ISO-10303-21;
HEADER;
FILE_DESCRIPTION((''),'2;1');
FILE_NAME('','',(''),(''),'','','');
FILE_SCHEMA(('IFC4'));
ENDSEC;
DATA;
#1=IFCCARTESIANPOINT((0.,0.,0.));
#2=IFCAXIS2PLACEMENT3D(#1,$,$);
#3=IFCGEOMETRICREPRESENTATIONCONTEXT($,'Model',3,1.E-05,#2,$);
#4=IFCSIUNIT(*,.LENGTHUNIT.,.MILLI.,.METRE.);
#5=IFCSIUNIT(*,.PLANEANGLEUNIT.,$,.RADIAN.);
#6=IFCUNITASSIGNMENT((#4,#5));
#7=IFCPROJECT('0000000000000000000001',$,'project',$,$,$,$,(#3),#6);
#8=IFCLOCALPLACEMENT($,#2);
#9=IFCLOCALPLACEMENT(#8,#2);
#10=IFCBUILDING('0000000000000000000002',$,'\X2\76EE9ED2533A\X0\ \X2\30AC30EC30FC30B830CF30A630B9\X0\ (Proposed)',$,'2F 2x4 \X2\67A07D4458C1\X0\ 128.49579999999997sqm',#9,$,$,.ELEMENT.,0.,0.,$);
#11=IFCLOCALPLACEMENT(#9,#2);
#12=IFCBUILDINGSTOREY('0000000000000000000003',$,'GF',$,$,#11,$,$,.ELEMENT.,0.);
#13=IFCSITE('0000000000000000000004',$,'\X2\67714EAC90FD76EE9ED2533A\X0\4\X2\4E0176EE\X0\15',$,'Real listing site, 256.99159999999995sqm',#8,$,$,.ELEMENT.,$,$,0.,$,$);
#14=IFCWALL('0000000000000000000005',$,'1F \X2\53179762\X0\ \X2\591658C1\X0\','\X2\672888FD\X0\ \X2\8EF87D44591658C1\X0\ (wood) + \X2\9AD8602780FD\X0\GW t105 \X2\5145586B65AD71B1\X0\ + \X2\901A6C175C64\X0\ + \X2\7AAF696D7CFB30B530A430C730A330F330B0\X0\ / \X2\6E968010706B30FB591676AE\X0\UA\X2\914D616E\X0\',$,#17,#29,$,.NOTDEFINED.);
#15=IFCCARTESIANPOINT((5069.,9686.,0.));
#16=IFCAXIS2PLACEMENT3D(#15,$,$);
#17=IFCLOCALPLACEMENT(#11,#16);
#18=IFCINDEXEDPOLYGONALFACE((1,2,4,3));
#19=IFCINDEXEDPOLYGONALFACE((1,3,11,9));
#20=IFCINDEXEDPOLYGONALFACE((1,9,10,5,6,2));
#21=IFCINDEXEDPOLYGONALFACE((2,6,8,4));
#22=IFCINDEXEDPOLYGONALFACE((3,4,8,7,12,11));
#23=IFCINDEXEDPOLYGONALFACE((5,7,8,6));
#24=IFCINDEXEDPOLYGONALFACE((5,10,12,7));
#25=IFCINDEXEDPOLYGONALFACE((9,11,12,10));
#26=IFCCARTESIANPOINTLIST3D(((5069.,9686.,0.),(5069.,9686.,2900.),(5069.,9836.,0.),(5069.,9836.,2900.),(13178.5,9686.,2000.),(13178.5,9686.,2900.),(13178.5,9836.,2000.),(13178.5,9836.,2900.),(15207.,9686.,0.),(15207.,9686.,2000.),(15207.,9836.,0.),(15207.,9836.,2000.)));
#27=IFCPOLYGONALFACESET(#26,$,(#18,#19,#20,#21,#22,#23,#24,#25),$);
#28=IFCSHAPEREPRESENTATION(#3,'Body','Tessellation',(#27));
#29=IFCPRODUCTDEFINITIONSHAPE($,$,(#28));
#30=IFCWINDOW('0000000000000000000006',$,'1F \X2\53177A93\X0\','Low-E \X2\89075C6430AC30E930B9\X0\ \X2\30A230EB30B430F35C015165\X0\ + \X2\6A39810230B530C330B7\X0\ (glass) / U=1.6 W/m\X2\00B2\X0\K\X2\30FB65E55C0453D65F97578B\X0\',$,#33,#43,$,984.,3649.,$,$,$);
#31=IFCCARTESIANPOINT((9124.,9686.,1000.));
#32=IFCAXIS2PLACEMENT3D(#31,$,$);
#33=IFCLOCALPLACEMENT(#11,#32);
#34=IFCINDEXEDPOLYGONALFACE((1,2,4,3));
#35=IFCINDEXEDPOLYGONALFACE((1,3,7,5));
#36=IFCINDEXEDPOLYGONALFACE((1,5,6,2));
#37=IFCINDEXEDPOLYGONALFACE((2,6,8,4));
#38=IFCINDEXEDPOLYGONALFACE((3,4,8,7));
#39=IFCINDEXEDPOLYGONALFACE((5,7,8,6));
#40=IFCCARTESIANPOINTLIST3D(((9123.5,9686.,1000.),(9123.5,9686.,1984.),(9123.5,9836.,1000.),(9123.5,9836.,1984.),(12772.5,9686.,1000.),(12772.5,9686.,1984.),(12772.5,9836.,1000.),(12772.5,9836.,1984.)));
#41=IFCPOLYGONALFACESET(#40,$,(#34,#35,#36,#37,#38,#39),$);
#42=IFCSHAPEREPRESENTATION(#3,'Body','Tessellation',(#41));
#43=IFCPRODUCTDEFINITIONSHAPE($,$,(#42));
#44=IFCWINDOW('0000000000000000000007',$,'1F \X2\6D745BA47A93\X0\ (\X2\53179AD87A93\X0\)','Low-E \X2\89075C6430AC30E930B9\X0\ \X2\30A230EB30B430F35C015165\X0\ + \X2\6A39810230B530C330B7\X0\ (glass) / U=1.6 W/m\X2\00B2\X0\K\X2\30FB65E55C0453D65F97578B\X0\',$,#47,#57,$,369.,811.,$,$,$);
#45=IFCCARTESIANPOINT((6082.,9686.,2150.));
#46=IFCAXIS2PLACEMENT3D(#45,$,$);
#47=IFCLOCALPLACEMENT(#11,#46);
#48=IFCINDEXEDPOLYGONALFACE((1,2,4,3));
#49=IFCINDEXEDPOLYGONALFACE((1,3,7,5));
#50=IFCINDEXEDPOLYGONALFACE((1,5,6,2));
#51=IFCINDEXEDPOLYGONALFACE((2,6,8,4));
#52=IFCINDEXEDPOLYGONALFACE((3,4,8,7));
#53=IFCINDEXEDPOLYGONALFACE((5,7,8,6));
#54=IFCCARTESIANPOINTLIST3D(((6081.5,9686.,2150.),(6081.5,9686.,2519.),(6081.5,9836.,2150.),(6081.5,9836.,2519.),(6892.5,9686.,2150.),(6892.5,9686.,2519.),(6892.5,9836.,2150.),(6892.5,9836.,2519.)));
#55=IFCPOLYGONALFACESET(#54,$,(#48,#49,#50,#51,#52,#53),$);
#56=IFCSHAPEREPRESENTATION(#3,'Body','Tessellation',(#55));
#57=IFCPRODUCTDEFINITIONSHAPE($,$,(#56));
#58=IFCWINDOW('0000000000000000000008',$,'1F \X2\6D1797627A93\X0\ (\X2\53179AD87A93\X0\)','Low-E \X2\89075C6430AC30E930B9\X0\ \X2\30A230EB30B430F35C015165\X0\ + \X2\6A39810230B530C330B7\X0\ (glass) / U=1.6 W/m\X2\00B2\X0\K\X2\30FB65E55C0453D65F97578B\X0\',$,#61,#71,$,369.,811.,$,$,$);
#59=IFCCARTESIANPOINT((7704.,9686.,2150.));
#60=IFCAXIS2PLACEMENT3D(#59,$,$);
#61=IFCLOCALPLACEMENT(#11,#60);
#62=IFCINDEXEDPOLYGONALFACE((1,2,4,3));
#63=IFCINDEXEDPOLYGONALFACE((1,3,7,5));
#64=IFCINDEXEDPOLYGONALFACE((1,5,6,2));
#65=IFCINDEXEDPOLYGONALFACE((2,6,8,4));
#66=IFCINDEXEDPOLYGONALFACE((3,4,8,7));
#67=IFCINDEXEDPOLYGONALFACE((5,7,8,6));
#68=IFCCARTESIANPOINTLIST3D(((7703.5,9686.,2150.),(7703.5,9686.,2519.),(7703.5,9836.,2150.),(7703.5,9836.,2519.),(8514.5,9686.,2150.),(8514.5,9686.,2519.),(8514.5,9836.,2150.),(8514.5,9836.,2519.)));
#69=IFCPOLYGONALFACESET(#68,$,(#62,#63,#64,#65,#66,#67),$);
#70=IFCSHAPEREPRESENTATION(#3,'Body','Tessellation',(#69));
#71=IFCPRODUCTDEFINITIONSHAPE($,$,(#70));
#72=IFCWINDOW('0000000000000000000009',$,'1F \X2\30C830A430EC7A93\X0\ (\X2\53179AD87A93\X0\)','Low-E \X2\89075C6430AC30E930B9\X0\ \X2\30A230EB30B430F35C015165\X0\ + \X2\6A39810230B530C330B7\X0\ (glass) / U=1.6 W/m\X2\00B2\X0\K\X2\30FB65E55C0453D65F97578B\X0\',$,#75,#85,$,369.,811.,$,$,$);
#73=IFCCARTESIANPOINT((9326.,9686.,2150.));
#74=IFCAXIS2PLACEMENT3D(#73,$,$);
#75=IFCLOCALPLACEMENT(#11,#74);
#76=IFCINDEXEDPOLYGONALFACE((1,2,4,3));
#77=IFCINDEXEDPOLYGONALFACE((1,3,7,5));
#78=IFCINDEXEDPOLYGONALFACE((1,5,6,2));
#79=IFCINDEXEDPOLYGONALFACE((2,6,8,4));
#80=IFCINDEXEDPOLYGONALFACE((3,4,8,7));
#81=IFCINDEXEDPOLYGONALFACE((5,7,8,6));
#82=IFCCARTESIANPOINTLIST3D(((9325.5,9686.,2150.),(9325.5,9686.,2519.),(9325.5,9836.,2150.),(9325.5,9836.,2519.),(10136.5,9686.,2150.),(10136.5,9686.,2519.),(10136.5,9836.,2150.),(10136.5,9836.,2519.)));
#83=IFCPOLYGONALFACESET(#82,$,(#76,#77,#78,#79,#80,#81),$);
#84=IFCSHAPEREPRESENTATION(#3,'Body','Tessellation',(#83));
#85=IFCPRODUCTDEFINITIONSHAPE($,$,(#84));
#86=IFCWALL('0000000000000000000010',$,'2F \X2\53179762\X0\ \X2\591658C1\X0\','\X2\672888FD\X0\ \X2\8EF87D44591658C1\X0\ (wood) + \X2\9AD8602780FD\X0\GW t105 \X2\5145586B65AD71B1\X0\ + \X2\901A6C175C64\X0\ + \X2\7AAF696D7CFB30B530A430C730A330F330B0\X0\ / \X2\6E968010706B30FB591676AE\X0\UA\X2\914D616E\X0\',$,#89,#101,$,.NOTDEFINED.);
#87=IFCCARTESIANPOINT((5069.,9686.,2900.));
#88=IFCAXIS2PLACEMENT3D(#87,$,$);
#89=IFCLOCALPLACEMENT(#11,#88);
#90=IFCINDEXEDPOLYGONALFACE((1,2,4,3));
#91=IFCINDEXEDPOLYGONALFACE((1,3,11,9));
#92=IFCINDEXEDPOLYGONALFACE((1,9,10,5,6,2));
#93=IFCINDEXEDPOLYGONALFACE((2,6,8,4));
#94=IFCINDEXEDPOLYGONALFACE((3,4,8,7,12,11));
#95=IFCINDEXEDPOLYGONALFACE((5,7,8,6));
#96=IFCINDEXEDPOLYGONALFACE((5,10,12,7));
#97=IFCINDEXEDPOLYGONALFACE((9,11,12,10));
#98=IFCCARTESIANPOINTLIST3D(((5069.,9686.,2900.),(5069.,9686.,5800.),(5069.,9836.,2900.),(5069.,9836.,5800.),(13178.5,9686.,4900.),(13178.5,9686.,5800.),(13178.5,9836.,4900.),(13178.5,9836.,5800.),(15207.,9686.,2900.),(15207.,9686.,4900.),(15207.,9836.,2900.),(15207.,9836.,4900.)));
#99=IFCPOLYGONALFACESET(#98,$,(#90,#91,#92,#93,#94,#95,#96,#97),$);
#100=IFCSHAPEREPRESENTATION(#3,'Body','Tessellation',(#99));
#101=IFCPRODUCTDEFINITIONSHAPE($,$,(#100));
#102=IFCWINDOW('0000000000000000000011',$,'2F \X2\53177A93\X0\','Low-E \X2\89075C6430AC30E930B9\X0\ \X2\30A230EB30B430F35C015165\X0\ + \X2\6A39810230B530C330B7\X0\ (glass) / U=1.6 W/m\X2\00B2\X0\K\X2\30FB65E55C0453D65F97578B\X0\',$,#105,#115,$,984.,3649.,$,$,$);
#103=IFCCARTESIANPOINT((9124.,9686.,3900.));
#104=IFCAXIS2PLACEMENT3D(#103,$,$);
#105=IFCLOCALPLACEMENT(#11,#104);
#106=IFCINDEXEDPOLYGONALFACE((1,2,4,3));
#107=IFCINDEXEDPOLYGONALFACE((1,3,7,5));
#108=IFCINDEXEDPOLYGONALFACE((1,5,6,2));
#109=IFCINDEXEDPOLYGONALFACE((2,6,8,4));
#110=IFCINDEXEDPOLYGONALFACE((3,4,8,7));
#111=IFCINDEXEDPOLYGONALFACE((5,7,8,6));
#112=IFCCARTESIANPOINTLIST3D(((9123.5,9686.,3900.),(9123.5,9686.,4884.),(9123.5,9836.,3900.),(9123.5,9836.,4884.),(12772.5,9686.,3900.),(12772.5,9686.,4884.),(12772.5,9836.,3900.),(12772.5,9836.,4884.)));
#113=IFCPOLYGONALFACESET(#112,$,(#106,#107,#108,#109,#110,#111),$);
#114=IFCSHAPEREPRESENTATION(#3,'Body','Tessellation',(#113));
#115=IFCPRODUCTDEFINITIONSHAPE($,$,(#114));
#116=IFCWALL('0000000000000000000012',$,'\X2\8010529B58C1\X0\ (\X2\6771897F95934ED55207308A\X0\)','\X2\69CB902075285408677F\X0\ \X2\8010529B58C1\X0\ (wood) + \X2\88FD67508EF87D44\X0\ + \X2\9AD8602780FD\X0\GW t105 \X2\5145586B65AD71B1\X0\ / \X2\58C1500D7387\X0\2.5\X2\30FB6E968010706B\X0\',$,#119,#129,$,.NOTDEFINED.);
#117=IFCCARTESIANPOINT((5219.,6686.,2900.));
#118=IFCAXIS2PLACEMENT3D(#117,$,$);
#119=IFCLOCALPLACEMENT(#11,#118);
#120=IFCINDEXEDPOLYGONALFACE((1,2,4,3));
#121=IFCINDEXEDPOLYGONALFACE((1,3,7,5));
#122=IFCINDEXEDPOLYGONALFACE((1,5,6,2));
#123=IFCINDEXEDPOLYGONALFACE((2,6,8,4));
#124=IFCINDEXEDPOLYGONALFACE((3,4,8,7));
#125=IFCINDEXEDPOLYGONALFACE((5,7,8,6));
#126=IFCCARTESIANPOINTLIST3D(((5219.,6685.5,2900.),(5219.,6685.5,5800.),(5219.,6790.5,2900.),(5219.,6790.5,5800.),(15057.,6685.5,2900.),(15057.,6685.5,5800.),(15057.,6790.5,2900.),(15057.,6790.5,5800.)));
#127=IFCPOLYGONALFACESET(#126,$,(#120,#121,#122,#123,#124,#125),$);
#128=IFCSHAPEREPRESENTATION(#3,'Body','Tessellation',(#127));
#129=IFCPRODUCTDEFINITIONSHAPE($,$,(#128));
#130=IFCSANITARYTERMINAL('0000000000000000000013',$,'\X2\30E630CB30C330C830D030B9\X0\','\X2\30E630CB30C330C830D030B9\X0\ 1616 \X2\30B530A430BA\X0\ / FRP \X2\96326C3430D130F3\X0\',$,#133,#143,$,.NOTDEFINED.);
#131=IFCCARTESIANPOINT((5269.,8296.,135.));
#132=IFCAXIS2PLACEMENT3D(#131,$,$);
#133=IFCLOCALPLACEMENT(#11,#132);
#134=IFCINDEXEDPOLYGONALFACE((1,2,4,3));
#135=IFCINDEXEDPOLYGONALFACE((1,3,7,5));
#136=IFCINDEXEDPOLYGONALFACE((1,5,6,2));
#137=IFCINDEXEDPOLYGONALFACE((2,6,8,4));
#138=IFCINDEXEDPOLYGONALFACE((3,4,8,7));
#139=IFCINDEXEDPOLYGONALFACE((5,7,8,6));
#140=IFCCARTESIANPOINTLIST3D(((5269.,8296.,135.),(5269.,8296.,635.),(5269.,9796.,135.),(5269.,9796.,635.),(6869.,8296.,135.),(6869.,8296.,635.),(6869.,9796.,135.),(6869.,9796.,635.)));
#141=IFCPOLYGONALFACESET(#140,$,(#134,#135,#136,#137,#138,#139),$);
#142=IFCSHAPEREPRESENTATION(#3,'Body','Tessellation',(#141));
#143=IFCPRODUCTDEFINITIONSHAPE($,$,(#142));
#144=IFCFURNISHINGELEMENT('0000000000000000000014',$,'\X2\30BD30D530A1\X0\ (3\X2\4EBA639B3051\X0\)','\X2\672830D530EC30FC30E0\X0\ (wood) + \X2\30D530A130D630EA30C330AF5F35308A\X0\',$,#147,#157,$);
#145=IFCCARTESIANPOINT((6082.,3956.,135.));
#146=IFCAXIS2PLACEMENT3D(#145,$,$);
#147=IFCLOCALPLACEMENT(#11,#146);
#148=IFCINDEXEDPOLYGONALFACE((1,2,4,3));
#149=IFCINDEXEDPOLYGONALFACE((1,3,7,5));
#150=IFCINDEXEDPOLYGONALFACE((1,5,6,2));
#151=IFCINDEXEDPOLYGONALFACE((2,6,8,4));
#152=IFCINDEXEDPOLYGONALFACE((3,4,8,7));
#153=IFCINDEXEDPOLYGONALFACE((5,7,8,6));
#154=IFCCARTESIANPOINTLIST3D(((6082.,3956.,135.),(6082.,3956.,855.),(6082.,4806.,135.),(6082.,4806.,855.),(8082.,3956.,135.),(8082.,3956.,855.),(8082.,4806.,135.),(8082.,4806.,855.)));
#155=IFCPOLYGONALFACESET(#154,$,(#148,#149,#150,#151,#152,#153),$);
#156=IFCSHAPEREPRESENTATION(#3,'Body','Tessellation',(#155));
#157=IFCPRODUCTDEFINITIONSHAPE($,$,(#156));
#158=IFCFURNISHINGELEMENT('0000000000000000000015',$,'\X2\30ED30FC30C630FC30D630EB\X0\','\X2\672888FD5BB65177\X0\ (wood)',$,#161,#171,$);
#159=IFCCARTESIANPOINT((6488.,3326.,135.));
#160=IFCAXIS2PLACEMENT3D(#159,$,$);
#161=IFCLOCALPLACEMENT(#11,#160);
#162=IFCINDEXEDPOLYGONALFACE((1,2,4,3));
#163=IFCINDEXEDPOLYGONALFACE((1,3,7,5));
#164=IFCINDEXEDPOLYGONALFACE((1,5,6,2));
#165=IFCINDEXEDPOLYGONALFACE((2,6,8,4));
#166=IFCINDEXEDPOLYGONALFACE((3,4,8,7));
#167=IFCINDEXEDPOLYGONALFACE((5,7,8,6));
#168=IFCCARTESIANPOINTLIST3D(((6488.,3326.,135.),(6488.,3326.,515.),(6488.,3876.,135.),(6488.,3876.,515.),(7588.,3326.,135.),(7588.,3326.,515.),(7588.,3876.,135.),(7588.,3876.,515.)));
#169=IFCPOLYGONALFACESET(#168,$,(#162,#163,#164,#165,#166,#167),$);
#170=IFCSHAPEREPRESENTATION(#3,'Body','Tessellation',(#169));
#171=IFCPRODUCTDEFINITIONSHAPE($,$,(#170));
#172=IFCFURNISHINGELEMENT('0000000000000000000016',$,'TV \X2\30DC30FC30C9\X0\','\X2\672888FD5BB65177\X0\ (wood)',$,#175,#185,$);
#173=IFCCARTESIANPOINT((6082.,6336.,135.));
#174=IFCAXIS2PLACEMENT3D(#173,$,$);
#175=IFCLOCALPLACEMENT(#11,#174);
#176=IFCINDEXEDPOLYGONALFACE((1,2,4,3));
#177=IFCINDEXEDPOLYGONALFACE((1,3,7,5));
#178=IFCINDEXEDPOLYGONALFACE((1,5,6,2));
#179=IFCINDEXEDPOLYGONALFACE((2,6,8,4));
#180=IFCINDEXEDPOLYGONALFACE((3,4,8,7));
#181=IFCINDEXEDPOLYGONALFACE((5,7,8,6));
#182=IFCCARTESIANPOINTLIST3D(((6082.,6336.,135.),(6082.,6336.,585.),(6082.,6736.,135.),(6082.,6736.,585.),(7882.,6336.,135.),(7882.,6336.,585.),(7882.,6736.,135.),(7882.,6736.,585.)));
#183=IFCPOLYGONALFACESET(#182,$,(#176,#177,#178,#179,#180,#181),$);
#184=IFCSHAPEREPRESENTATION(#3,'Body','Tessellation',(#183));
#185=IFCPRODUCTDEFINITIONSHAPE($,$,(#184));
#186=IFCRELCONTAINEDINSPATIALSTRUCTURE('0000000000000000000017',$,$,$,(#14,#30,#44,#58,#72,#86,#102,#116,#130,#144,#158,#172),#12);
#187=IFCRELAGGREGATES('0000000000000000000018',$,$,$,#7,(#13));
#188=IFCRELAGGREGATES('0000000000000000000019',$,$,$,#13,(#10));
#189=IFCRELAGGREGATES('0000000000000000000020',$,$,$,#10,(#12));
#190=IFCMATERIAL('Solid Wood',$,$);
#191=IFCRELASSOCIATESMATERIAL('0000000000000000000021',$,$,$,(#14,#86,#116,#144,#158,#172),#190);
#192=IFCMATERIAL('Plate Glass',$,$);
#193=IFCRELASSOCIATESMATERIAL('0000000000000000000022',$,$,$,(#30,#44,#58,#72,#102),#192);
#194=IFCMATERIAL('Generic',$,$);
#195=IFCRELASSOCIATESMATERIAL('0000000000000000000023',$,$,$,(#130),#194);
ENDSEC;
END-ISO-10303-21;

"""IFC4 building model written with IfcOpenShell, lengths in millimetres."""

from ifc_helpers import new_model, si_unit, frame, frame_2d, origin, place, context, project, spatial, rectangle, extrude, material, element, fill, save


model = new_model("IFC4")

# Units and contexts
model_context = context("Model", 3, precision=1e-05, world=origin())
ifc_project = project(units=[si_unit("LENGTHUNIT", "METRE", prefix="MILLI"), si_unit("PLANEANGLEUNIT", "RADIAN")], contexts=[model_context])

# Site, building, storey
site_placement = place(None, origin())
site = spatial("IfcSite", under=ifc_project, at=site_placement, Name="東京都目黒区4丁目15", ObjectType="Real listing site, 256.99159999999995sqm", CompositionType="ELEMENT", RefElevation=0.0)
building_placement = place(site_placement, origin())
building = spatial("IfcBuilding", under=site, at=building_placement, Name="目黒区 ガレージハウス (Proposed)", ObjectType="2F 2x4 枠組壁 128.49579999999997sqm", CompositionType="ELEMENT", ElevationOfRefHeight=0.0, ElevationOfTerrain=0.0)
storey_placement = place(building_placement, origin())
storey = spatial("IfcBuildingStorey", under=building, at=storey_placement, Name="GF", CompositionType="ELEMENT", Elevation=0.0)

# Wall, openings, windows
ifc_material_1 = material(Name="Solid Wood")
wall_1_placement = place(storey_placement, frame((5069.0, 9686.0, 0.0)))
wall_1 = element("IfcWall", 1, at=wall_1_placement, inside=storey, material=ifc_material_1, Name="1F 北面 外壁", Description="木製 軸組外壁 (wood) + 高性能GW t105 充填断熱 + 通気層 + 窯業系サイディング / 準耐火・外皮UA配慮", PredefinedType="NOTDEFINED", context=model_context, shape_type="SweptSolid", body=[
    extrude(rectangle(XDim=10138.0, YDim=150.0, at=frame_2d((5069.0, 75.0))), frame((5069.0, 9686.0, 0.0)), (0.0, 0.0, 1.0), 2900.0),
])
opening_1_placement = place(storey_placement, frame((9124.0, 9686.0, 1000.0)))
opening_1 = element("IfcOpeningElement", 2, at=opening_1_placement, cuts=wall_1, PredefinedType="NOTDEFINED", context=model_context, shape_type="SweptSolid", body=[
    extrude(rectangle(XDim=3649.0, YDim=150.0, at=frame_2d((1824.0, 75.0))), frame((9124.0, 9686.0, 1000.0)), (0.0, 0.0, 1.0), 984.0),
])
opening_2_placement = place(storey_placement, frame((6082.0, 9686.0, 2150.0)))
opening_2 = element("IfcOpeningElement", 3, at=opening_2_placement, cuts=wall_1, PredefinedType="NOTDEFINED", context=model_context, shape_type="SweptSolid", body=[
    extrude(rectangle(XDim=811.0, YDim=150.0, at=frame_2d((405.0, 75.0))), frame((6082.0, 9686.0, 2150.0)), (0.0, 0.0, 1.0), 369.0),
])
opening_3_placement = place(storey_placement, frame((7704.0, 9686.0, 2150.0)))
opening_3 = element("IfcOpeningElement", 4, at=opening_3_placement, cuts=wall_1, PredefinedType="NOTDEFINED", context=model_context, shape_type="SweptSolid", body=[
    extrude(rectangle(XDim=811.0, YDim=150.0, at=frame_2d((405.0, 75.0))), frame((7704.0, 9686.0, 2150.0)), (0.0, 0.0, 1.0), 369.0),
])
opening_4_placement = place(storey_placement, frame((9326.0, 9686.0, 2150.0)))
opening_4 = element("IfcOpeningElement", 5, at=opening_4_placement, cuts=wall_1, PredefinedType="NOTDEFINED", context=model_context, shape_type="SweptSolid", body=[
    extrude(rectangle(XDim=811.0, YDim=150.0, at=frame_2d((405.0, 75.0))), frame((9326.0, 9686.0, 2150.0)), (0.0, 0.0, 1.0), 369.0),
])
ifc_material_2 = material(Name="Plate Glass")
window_1_placement = place(storey_placement, frame((9124.0, 9686.0, 1000.0)))
window_1 = element("IfcWindow", 6, at=window_1_placement, inside=storey, material=ifc_material_2, Name="1F 北窓", Description="Low-E 複層ガラス アルゴン封入 + 樹脂サッシ (glass) / U=1.6 W/m²K・日射取得型", OverallHeight=984.0, OverallWidth=3649.0, context=model_context, shape_type="SweptSolid", body=[
    extrude(rectangle(XDim=3649.0, YDim=150.0, at=frame_2d((1824.0, 75.0))), frame((9124.0, 9686.0, 1000.0)), (0.0, 0.0, 1.0), 984.0),
])
fill(opening_1, window_1)
window_2_placement = place(storey_placement, frame((6082.0, 9686.0, 2150.0)))
window_2 = element("IfcWindow", 7, at=window_2_placement, inside=storey, material=ifc_material_2, Name="1F 浴室窓 (北高窓)", Description="Low-E 複層ガラス アルゴン封入 + 樹脂サッシ (glass) / U=1.6 W/m²K・日射取得型", OverallHeight=369.0, OverallWidth=811.0, context=model_context, shape_type="SweptSolid", body=[
    extrude(rectangle(XDim=811.0, YDim=150.0, at=frame_2d((405.0, 75.0))), frame((6082.0, 9686.0, 2150.0)), (0.0, 0.0, 1.0), 369.0),
])
fill(opening_2, window_2)
window_3_placement = place(storey_placement, frame((7704.0, 9686.0, 2150.0)))
window_3 = element("IfcWindow", 8, at=window_3_placement, inside=storey, material=ifc_material_2, Name="1F 洗面窓 (北高窓)", Description="Low-E 複層ガラス アルゴン封入 + 樹脂サッシ (glass) / U=1.6 W/m²K・日射取得型", OverallHeight=369.0, OverallWidth=811.0, context=model_context, shape_type="SweptSolid", body=[
    extrude(rectangle(XDim=811.0, YDim=150.0, at=frame_2d((405.0, 75.0))), frame((7704.0, 9686.0, 2150.0)), (0.0, 0.0, 1.0), 369.0),
])
fill(opening_3, window_3)
window_4_placement = place(storey_placement, frame((9326.0, 9686.0, 2150.0)))
window_4 = element("IfcWindow", 9, at=window_4_placement, inside=storey, material=ifc_material_2, Name="1F トイレ窓 (北高窓)", Description="Low-E 複層ガラス アルゴン封入 + 樹脂サッシ (glass) / U=1.6 W/m²K・日射取得型", OverallHeight=369.0, OverallWidth=811.0, context=model_context, shape_type="SweptSolid", body=[
    extrude(rectangle(XDim=811.0, YDim=150.0, at=frame_2d((405.0, 75.0))), frame((9326.0, 9686.0, 2150.0)), (0.0, 0.0, 1.0), 369.0),
])
fill(opening_4, window_4)

# Wall, opening, window
wall_2_placement = place(storey_placement, frame((5069.0, 9686.0, 2900.0)))
wall_2 = element("IfcWall", 10, at=wall_2_placement, inside=storey, material=ifc_material_1, Name="2F 北面 外壁", Description="木製 軸組外壁 (wood) + 高性能GW t105 充填断熱 + 通気層 + 窯業系サイディング / 準耐火・外皮UA配慮", PredefinedType="NOTDEFINED", context=model_context, shape_type="SweptSolid", body=[
    extrude(rectangle(XDim=10138.0, YDim=150.0, at=frame_2d((5069.0, 75.0))), frame((5069.0, 9686.0, 2900.0)), (0.0, 0.0, 1.0), 2900.0),
])
opening_5_placement = place(storey_placement, frame((9124.0, 9686.0, 3900.0)))
opening_5 = element("IfcOpeningElement", 11, at=opening_5_placement, cuts=wall_2, PredefinedType="NOTDEFINED", context=model_context, shape_type="SweptSolid", body=[
    extrude(rectangle(XDim=3649.0, YDim=150.0, at=frame_2d((1824.0, 75.0))), frame((9124.0, 9686.0, 3900.0)), (0.0, 0.0, 1.0), 984.0),
])
window_5_placement = place(storey_placement, frame((9124.0, 9686.0, 3900.0)))
window_5 = element("IfcWindow", 12, at=window_5_placement, inside=storey, material=ifc_material_2, Name="2F 北窓", Description="Low-E 複層ガラス アルゴン封入 + 樹脂サッシ (glass) / U=1.6 W/m²K・日射取得型", OverallHeight=984.0, OverallWidth=3649.0, context=model_context, shape_type="SweptSolid", body=[
    extrude(rectangle(XDim=3649.0, YDim=150.0, at=frame_2d((1824.0, 75.0))), frame((9124.0, 9686.0, 3900.0)), (0.0, 0.0, 1.0), 984.0),
])
fill(opening_5, window_5)

# Wall
wall_3_placement = place(storey_placement, frame((5219.0, 6686.0, 2900.0)))
element("IfcWall", 13, at=wall_3_placement, inside=storey, material=ifc_material_1, Name="耐力壁 (東西間仕切り)", Description="構造用合板 耐力壁 (wood) + 製材軸組 + 高性能GW t105 充填断熱 / 壁倍率2.5・準耐火", PredefinedType="NOTDEFINED", context=model_context, shape_type="SweptSolid", body=[
    extrude(rectangle(XDim=9838.0, YDim=105.0, at=frame_2d((4919.0, 52.0))), frame((5219.0, 6686.0, 2900.0)), (0.0, 0.0, 1.0), 2900.0),
])

# Sanitary terminal
ifc_material_3 = material(Name="Generic")
sanitary_terminal_placement = place(storey_placement, frame((5269.0, 8296.0, 135.0)))
element("IfcSanitaryTerminal", 14, at=sanitary_terminal_placement, inside=storey, material=ifc_material_3, Name="ユニットバス", Description="ユニットバス 1616 サイズ / FRP 防水パン", PredefinedType="NOTDEFINED", context=model_context, shape_type="SweptSolid", body=[
    extrude(rectangle(XDim=1600.0, YDim=1500.0, at=frame_2d((800.0, 750.0))), frame((5269.0, 8296.0, 135.0)), (0.0, 0.0, 1.0), 500.0),
])

# Furnishing elements
furnishing_1_placement = place(storey_placement, frame((6082.0, 3956.0, 135.0)))
element("IfcFurnishingElement", 15, at=furnishing_1_placement, inside=storey, material=ifc_material_1, Name="ソファ (3人掛け)", Description="木フレーム (wood) + ファブリック張り", context=model_context, shape_type="SweptSolid", body=[
    extrude(rectangle(XDim=2000.0, YDim=850.0, at=frame_2d((1000.0, 425.0))), frame((6082.0, 3956.0, 135.0)), (0.0, 0.0, 1.0), 720.0),
])
furnishing_2_placement = place(storey_placement, frame((6488.0, 3326.0, 135.0)))
element("IfcFurnishingElement", 16, at=furnishing_2_placement, inside=storey, material=ifc_material_1, Name="ローテーブル", Description="木製家具 (wood)", context=model_context, shape_type="SweptSolid", body=[
    extrude(rectangle(XDim=1100.0, YDim=550.0, at=frame_2d((550.0, 275.0))), frame((6488.0, 3326.0, 135.0)), (0.0, 0.0, 1.0), 380.0),
])
furnishing_3_placement = place(storey_placement, frame((6082.0, 6336.0, 135.0)))
element("IfcFurnishingElement", 17, at=furnishing_3_placement, inside=storey, material=ifc_material_1, Name="TV ボード", Description="木製家具 (wood)", context=model_context, shape_type="SweptSolid", body=[
    extrude(rectangle(XDim=1800.0, YDim=400.0, at=frame_2d((900.0, 200.0))), frame((6082.0, 6336.0, 135.0)), (0.0, 0.0, 1.0), 450.0),
])

save(model, "model.ifc")
